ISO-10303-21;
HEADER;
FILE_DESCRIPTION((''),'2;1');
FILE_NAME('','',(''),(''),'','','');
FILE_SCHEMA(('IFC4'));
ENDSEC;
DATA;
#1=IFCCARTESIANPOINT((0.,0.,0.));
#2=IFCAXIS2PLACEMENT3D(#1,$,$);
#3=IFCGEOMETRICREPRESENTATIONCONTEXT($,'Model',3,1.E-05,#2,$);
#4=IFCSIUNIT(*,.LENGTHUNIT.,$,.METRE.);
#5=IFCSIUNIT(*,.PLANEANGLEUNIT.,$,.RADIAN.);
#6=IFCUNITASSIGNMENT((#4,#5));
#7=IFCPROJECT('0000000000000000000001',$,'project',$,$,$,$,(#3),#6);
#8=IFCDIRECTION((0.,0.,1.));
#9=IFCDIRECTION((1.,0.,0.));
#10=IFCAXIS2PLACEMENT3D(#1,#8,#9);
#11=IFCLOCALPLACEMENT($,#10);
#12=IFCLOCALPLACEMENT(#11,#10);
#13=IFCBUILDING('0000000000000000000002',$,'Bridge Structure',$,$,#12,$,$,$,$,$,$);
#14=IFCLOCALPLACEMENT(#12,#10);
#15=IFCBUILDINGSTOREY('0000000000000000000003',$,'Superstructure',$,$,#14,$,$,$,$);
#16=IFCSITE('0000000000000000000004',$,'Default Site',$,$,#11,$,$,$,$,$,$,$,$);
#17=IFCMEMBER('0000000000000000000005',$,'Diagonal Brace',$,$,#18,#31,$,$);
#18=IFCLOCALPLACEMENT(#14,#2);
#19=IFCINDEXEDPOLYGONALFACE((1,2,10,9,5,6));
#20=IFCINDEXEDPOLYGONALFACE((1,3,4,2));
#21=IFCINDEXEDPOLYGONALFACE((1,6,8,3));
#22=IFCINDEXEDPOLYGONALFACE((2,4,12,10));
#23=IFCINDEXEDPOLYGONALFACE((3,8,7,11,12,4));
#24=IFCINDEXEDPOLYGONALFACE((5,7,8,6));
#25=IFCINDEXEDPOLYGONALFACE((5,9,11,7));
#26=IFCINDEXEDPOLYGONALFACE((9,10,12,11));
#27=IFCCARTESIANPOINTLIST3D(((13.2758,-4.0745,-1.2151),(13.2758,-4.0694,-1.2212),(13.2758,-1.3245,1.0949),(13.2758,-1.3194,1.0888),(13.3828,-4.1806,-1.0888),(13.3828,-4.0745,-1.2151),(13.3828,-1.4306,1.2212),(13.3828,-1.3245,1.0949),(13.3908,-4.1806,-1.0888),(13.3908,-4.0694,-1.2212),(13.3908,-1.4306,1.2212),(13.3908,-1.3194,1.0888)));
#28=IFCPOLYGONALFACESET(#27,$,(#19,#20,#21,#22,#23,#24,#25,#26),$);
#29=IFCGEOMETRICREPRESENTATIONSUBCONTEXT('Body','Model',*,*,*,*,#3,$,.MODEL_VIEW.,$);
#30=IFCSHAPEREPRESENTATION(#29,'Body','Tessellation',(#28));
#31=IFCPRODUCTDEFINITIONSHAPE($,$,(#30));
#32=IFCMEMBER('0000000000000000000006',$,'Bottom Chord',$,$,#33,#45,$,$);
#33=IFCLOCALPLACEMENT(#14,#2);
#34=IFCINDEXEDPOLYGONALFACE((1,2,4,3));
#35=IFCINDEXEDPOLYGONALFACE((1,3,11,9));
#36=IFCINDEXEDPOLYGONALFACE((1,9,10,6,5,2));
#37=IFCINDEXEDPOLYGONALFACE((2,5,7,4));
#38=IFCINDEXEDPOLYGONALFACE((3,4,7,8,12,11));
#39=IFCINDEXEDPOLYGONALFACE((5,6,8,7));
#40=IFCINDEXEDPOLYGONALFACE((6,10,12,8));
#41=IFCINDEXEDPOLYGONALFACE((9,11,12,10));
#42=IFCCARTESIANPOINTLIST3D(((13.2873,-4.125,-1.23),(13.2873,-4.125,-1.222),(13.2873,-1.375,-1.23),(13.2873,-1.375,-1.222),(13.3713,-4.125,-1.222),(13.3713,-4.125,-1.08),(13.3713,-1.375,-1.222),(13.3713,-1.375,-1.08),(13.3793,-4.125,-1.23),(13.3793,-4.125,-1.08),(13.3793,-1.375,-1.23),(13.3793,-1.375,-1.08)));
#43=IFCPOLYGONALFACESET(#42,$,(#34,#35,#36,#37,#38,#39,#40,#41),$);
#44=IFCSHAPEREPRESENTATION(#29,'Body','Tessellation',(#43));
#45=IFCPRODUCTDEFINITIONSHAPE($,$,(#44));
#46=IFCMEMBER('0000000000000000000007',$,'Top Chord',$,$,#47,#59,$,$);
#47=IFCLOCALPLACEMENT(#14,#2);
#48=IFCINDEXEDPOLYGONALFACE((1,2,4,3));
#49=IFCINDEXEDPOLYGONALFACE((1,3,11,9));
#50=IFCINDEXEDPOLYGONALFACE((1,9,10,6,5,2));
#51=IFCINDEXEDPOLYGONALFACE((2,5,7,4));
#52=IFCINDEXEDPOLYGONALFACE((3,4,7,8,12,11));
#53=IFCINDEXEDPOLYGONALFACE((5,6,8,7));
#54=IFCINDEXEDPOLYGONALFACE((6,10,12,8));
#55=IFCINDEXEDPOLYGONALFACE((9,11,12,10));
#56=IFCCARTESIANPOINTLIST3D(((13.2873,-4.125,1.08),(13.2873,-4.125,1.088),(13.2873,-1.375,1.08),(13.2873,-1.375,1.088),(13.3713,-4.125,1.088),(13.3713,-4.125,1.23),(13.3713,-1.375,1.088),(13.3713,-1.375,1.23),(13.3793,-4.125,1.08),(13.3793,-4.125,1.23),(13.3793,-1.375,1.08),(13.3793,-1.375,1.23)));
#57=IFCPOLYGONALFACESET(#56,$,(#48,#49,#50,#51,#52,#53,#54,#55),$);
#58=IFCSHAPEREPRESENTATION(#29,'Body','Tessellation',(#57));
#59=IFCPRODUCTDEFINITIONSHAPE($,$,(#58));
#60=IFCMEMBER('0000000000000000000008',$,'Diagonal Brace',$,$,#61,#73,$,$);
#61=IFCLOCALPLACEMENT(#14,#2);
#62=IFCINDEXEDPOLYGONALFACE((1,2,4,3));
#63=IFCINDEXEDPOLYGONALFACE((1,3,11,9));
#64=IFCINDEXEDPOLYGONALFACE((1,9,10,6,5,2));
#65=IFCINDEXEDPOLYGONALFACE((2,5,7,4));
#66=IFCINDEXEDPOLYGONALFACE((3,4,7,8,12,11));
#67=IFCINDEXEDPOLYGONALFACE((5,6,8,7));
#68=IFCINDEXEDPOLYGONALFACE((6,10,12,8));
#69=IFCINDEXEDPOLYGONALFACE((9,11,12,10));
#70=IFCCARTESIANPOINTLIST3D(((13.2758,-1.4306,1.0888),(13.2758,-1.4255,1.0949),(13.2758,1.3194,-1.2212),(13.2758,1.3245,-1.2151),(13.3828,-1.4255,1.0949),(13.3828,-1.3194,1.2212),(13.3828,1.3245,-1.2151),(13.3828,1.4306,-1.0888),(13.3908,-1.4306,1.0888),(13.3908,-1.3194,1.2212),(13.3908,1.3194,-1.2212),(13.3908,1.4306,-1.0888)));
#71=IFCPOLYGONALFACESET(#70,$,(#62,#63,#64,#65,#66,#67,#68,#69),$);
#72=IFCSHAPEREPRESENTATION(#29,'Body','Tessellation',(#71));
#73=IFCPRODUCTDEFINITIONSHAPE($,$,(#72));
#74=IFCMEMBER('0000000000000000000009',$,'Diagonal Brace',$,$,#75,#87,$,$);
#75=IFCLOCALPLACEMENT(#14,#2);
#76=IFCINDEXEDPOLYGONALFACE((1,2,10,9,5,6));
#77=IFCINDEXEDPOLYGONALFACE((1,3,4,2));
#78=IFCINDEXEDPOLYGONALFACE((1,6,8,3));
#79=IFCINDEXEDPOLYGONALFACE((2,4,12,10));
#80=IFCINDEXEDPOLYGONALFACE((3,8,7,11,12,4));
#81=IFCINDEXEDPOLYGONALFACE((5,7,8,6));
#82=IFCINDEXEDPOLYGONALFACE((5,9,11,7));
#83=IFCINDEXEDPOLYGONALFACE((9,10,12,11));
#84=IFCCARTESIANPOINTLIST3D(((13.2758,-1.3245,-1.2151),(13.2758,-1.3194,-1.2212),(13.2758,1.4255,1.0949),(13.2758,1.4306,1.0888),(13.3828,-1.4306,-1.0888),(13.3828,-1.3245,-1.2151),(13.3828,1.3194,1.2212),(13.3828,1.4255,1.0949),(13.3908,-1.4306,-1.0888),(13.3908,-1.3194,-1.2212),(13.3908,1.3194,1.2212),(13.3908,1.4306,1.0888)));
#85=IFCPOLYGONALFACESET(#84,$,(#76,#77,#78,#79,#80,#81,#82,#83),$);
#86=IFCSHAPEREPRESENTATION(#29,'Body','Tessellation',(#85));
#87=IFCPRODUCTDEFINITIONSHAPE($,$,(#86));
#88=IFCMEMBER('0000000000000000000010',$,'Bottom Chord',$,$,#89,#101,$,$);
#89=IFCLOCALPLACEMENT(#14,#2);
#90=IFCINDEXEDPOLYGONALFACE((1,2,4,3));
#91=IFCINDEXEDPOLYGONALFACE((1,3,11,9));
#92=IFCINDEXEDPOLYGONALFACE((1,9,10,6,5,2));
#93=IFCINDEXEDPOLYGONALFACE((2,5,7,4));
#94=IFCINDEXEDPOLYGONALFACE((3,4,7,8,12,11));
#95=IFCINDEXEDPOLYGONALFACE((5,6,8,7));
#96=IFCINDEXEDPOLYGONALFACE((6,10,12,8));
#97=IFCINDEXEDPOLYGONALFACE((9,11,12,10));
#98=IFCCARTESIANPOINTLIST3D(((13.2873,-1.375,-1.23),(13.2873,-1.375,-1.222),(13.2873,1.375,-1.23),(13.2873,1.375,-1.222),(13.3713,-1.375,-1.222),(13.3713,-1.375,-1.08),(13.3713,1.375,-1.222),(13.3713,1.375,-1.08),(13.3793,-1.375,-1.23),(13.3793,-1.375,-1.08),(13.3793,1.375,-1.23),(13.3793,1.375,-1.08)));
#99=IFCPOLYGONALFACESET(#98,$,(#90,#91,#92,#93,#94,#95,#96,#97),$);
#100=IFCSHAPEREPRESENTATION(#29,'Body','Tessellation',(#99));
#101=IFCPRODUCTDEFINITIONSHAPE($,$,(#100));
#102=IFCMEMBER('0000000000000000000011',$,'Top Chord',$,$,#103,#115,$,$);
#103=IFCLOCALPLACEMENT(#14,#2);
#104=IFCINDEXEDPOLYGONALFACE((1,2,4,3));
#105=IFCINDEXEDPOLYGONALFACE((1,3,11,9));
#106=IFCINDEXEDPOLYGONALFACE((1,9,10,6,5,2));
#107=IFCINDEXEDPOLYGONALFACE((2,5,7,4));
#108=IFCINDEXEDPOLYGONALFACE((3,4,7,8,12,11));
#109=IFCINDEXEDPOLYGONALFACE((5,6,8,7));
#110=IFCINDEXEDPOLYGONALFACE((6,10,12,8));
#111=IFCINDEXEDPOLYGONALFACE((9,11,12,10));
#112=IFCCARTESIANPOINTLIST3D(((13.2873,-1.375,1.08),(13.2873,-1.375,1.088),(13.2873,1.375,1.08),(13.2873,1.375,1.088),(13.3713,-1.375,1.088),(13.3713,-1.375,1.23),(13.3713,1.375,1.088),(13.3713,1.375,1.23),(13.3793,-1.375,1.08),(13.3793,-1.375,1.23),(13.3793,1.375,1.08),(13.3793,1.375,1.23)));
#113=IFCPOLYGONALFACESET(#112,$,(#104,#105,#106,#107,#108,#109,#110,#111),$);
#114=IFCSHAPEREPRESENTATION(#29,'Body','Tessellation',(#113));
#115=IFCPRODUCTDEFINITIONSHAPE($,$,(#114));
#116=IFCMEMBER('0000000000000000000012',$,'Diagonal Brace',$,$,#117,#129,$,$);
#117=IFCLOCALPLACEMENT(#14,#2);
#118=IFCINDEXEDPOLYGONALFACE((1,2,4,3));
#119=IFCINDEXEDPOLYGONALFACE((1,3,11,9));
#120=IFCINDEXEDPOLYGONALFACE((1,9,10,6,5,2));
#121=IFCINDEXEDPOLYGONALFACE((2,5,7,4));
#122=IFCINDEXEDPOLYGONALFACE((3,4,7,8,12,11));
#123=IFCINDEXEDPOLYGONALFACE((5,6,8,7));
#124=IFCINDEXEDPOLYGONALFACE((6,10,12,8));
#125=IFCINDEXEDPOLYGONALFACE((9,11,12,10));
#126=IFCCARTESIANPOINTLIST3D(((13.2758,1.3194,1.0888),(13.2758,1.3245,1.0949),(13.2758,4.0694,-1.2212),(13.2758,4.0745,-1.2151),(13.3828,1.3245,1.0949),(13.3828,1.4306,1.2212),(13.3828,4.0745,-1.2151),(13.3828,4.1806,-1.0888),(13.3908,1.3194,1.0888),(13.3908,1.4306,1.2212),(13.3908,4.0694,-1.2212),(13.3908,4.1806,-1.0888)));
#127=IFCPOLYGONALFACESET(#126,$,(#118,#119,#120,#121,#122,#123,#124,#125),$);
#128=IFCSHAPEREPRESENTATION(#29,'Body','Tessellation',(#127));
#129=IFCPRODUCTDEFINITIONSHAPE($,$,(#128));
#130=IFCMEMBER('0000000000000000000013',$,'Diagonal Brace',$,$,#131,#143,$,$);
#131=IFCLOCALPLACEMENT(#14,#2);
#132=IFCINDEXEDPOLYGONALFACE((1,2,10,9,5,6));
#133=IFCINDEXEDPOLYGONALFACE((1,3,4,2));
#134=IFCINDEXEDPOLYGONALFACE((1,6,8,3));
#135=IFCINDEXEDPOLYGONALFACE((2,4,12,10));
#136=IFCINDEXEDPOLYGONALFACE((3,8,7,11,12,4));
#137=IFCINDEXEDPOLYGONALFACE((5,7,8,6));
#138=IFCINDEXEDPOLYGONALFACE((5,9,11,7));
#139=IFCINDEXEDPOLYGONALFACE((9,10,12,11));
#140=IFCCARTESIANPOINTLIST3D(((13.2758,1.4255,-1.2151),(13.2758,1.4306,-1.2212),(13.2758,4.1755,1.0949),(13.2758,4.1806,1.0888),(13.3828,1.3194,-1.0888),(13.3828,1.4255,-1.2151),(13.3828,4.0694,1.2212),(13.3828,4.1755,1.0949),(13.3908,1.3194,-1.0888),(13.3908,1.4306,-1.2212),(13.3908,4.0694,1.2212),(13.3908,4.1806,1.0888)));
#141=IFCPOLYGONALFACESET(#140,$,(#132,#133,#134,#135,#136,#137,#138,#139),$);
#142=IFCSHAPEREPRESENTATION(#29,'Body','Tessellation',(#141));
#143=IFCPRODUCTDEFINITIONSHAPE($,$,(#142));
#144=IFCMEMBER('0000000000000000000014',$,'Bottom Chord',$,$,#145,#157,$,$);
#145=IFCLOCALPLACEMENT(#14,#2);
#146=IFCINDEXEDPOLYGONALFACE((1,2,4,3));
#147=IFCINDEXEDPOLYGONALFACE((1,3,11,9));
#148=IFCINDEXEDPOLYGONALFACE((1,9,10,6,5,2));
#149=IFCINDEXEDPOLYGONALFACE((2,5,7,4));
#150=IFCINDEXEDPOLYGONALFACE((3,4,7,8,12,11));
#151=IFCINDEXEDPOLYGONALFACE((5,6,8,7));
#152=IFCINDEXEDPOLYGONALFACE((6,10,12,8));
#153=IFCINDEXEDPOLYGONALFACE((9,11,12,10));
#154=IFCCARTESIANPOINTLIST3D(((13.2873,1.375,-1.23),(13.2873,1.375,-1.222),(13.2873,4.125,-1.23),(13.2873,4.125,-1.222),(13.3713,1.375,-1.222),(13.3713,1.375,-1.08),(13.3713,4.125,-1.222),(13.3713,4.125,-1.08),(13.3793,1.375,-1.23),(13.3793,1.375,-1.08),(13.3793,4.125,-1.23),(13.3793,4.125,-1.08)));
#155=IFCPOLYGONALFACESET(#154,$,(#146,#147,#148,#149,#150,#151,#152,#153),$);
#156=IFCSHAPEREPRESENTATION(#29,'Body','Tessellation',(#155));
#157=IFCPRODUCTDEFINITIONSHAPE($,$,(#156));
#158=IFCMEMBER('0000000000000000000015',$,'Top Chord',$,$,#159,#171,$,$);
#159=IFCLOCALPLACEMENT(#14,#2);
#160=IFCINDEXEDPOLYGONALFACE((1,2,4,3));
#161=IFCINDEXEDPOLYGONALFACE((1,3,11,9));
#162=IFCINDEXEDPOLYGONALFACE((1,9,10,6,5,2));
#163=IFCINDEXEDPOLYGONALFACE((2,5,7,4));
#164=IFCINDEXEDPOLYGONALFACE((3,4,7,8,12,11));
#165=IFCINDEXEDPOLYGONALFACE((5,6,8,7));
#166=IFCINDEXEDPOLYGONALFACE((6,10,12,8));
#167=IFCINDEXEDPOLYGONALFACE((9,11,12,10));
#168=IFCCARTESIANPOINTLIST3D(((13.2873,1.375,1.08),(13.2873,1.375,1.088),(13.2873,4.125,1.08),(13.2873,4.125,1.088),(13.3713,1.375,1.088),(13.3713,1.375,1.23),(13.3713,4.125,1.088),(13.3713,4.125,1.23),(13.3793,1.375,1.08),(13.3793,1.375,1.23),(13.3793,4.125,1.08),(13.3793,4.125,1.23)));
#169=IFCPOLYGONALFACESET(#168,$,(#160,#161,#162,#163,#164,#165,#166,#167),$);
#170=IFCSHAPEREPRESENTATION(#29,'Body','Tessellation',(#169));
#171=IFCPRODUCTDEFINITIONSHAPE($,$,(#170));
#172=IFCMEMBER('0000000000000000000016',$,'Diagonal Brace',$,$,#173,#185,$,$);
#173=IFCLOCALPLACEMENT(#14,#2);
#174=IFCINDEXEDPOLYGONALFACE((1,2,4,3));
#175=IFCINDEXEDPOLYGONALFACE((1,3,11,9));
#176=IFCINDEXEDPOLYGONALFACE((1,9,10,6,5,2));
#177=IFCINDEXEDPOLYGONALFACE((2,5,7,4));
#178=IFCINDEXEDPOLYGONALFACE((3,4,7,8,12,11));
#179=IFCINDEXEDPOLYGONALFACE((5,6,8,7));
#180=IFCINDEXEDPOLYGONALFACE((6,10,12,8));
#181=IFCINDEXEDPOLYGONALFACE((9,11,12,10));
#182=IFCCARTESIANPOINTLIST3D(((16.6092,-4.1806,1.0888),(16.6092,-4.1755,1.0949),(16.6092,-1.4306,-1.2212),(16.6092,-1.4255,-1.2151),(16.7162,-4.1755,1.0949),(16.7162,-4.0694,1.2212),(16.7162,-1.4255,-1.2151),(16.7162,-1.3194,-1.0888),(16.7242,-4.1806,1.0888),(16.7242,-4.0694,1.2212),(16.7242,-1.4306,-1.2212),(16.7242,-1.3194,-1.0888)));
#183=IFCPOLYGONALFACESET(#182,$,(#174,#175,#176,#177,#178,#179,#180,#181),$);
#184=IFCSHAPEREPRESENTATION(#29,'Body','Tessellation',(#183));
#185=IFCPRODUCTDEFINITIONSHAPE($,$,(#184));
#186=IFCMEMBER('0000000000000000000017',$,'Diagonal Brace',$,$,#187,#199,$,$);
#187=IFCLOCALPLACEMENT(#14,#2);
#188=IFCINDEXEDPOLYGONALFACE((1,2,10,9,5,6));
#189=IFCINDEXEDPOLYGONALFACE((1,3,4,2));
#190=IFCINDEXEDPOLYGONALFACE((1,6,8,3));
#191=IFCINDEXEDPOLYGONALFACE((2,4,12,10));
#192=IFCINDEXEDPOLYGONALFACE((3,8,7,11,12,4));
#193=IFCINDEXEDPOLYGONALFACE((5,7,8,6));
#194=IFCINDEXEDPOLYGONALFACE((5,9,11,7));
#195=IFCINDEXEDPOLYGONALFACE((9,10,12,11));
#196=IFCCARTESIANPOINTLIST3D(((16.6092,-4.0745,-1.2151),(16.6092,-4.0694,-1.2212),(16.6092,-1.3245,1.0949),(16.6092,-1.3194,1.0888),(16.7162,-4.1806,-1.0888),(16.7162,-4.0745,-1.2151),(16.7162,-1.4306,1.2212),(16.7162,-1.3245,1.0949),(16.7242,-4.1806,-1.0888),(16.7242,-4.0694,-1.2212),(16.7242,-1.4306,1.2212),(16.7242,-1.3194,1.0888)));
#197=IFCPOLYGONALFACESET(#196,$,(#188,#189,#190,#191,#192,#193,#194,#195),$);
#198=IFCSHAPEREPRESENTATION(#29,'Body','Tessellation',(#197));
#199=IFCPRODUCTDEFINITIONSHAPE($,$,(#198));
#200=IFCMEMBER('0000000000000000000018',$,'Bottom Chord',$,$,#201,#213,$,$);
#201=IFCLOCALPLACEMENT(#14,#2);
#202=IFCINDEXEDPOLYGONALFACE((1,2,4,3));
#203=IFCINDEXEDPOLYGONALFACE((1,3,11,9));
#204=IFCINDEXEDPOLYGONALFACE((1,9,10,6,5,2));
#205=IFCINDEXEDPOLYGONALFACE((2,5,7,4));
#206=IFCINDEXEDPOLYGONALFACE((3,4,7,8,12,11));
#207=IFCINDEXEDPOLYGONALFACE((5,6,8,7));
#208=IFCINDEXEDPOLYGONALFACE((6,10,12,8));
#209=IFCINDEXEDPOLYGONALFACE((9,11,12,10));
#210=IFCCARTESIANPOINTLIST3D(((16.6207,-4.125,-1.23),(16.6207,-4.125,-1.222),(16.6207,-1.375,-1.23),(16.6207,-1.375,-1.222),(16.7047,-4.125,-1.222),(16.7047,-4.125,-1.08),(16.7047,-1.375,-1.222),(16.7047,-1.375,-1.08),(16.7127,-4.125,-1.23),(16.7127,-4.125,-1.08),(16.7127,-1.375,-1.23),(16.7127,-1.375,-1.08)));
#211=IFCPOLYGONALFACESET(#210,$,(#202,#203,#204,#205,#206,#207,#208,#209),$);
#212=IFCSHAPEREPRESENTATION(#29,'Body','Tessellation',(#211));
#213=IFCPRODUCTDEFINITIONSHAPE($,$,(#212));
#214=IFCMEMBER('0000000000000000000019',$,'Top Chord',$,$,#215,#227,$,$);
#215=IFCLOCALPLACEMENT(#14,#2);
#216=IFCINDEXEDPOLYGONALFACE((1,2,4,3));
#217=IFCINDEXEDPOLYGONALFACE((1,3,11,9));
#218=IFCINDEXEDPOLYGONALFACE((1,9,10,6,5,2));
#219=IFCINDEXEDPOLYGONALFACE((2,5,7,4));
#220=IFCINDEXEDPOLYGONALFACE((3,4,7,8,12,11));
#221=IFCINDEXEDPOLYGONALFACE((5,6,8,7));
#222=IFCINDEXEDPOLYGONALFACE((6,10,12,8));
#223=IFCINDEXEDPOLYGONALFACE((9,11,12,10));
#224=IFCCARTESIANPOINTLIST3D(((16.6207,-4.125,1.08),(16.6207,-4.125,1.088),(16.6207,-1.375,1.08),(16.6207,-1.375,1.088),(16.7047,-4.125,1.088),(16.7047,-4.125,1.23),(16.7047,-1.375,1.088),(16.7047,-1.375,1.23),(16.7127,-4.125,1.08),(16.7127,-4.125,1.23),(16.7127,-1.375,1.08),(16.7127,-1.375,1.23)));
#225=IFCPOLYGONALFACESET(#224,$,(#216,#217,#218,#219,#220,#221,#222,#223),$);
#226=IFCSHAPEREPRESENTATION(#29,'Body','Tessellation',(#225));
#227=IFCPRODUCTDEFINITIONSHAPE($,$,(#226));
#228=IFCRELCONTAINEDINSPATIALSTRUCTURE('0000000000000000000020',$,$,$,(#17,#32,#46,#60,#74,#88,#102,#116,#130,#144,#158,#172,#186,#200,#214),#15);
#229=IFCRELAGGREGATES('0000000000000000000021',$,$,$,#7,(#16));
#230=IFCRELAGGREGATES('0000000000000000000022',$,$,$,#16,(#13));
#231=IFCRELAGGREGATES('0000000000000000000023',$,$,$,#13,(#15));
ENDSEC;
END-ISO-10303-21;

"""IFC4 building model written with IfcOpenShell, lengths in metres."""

from ifc_helpers import new_model, si_unit, frame, origin, origin_with_axes, origin_2d_with_axis, place, context, subcontext, project, spatial, l_section, extrude, element, save


model = new_model("IFC4")

# Units and contexts
model_context = context("Model", 3, precision=1e-05, world=origin())
body_context = subcontext(model_context, "Body", "Model", "MODEL_VIEW")
ifc_project = project(units=[si_unit("LENGTHUNIT", "METRE"), si_unit("PLANEANGLEUNIT", "RADIAN")], contexts=[model_context])

# Site, building, storey
site_placement = place(None, origin_with_axes())
site = spatial("IfcSite", under=ifc_project, at=site_placement, Name="Default Site")
building_placement = place(site_placement, origin_with_axes())
building = spatial("IfcBuilding", under=site, at=building_placement, Name="Bridge Structure")
storey_placement = place(building_placement, origin_with_axes())
storey = spatial("IfcBuildingStorey", under=building, at=storey_placement, Name="Superstructure")

# Members
member_placement = place(storey_placement, frame((13.3333, -4.125, -1.155), z_axis=(0.0, 0.765705, 0.643192), x_axis=(-1.0, 0.0, 0.0)))
element("IfcMember", 1, at=member_placement, inside=storey, Name="Diagonal Brace", context=body_context, shape_type="SweptSolid", body=[
    extrude(l_section(Depth=0.173, Width=0.115, Thickness=0.008, at=origin_2d_with_axis()), origin_with_axes(), (0.0, 0.0, 1.0), 3.5915),
])
for number, where, z_axis, x_axis, name in (
    (2, (13.3333, -4.125, -1.155), (0.0, 1.0, 0.0), (-1.0, 0.0, 0.0), "Bottom Chord"),
    (3, (13.3333, -4.125, 1.155), (0.0, 1.0, 0.0), (-1.0, 0.0, 0.0), "Top Chord"),
):
    element("IfcMember", number, at=place(storey_placement, frame(where, z_axis=z_axis, x_axis=x_axis)), inside=storey, Name=name, context=body_context, shape_type="SweptSolid", body=[
        extrude(l_section(Depth=0.15, Width=0.092, Thickness=0.008, at=origin_2d_with_axis()), origin_with_axes(), (0.0, 0.0, 1.0), 2.75),
    ])
for number, where, z_axis, x_axis, name in (
    (4, (13.3333, -1.375, 1.155), (0.0, 0.765705, -0.643192), (-1.0, 0.0, 0.0), "Diagonal Brace"),
    (5, (13.3333, -1.375, -1.155), (0.0, 0.765705, 0.643192), (-1.0, 0.0, 0.0), "Diagonal Brace"),
):
    element("IfcMember", number, at=place(storey_placement, frame(where, z_axis=z_axis, x_axis=x_axis)), inside=storey, Name=name, context=body_context, shape_type="SweptSolid", body=[
        extrude(l_section(Depth=0.173, Width=0.115, Thickness=0.008, at=origin_2d_with_axis()), origin_with_axes(), (0.0, 0.0, 1.0), 3.5915),
    ])
for number, where, z_axis, x_axis, name in (
    (6, (13.3333, -1.375, -1.155), (0.0, 1.0, 0.0), (-1.0, 0.0, 0.0), "Bottom Chord"),
    (7, (13.3333, -1.375, 1.155), (0.0, 1.0, 0.0), (-1.0, 0.0, 0.0), "Top Chord"),
):
    element("IfcMember", number, at=place(storey_placement, frame(where, z_axis=z_axis, x_axis=x_axis)), inside=storey, Name=name, context=body_context, shape_type="SweptSolid", body=[
        extrude(l_section(Depth=0.15, Width=0.092, Thickness=0.008, at=origin_2d_with_axis()), origin_with_axes(), (0.0, 0.0, 1.0), 2.75),
    ])
for number, where, z_axis, x_axis, name in (
    (8, (13.3333, 1.375, 1.155), (0.0, 0.765705, -0.643192), (-1.0, 0.0, 0.0), "Diagonal Brace"),
    (9, (13.3333, 1.375, -1.155), (0.0, 0.765705, 0.643192), (-1.0, 0.0, 0.0), "Diagonal Brace"),
):
    element("IfcMember", number, at=place(storey_placement, frame(where, z_axis=z_axis, x_axis=x_axis)), inside=storey, Name=name, context=body_context, shape_type="SweptSolid", body=[
        extrude(l_section(Depth=0.173, Width=0.115, Thickness=0.008, at=origin_2d_with_axis()), origin_with_axes(), (0.0, 0.0, 1.0), 3.5915),
    ])
for number, where, z_axis, x_axis, name in (
    (10, (13.3333, 1.375, -1.155), (0.0, 1.0, 0.0), (-1.0, 0.0, 0.0), "Bottom Chord"),
    (11, (13.3333, 1.375, 1.155), (0.0, 1.0, 0.0), (-1.0, 0.0, 0.0), "Top Chord"),
):
    element("IfcMember", number, at=place(storey_placement, frame(where, z_axis=z_axis, x_axis=x_axis)), inside=storey, Name=name, context=body_context, shape_type="SweptSolid", body=[
        extrude(l_section(Depth=0.15, Width=0.092, Thickness=0.008, at=origin_2d_with_axis()), origin_with_axes(), (0.0, 0.0, 1.0), 2.75),
    ])
for number, where, z_axis, x_axis, name in (
    (12, (16.6667, -4.125, 1.155), (0.0, 0.765705, -0.643192), (-1.0, 0.0, 0.0), "Diagonal Brace"),
    (13, (16.6667, -4.125, -1.155), (0.0, 0.765705, 0.643192), (-1.0, 0.0, 0.0), "Diagonal Brace"),
):
    element("IfcMember", number, at=place(storey_placement, frame(where, z_axis=z_axis, x_axis=x_axis)), inside=storey, Name=name, context=body_context, shape_type="SweptSolid", body=[
        extrude(l_section(Depth=0.173, Width=0.115, Thickness=0.008, at=origin_2d_with_axis()), origin_with_axes(), (0.0, 0.0, 1.0), 3.5915),
    ])
for number, where, z_axis, x_axis, name in (
    (14, (16.6667, -4.125, -1.155), (0.0, 1.0, 0.0), (-1.0, 0.0, 0.0), "Bottom Chord"),
    (15, (16.6667, -4.125, 1.155), (0.0, 1.0, 0.0), (-1.0, 0.0, 0.0), "Top Chord"),
):
    element("IfcMember", number, at=place(storey_placement, frame(where, z_axis=z_axis, x_axis=x_axis)), inside=storey, Name=name, context=body_context, shape_type="SweptSolid", body=[
        extrude(l_section(Depth=0.15, Width=0.092, Thickness=0.008, at=origin_2d_with_axis()), origin_with_axes(), (0.0, 0.0, 1.0), 2.75),
    ])

save(model, "model.ifc")
